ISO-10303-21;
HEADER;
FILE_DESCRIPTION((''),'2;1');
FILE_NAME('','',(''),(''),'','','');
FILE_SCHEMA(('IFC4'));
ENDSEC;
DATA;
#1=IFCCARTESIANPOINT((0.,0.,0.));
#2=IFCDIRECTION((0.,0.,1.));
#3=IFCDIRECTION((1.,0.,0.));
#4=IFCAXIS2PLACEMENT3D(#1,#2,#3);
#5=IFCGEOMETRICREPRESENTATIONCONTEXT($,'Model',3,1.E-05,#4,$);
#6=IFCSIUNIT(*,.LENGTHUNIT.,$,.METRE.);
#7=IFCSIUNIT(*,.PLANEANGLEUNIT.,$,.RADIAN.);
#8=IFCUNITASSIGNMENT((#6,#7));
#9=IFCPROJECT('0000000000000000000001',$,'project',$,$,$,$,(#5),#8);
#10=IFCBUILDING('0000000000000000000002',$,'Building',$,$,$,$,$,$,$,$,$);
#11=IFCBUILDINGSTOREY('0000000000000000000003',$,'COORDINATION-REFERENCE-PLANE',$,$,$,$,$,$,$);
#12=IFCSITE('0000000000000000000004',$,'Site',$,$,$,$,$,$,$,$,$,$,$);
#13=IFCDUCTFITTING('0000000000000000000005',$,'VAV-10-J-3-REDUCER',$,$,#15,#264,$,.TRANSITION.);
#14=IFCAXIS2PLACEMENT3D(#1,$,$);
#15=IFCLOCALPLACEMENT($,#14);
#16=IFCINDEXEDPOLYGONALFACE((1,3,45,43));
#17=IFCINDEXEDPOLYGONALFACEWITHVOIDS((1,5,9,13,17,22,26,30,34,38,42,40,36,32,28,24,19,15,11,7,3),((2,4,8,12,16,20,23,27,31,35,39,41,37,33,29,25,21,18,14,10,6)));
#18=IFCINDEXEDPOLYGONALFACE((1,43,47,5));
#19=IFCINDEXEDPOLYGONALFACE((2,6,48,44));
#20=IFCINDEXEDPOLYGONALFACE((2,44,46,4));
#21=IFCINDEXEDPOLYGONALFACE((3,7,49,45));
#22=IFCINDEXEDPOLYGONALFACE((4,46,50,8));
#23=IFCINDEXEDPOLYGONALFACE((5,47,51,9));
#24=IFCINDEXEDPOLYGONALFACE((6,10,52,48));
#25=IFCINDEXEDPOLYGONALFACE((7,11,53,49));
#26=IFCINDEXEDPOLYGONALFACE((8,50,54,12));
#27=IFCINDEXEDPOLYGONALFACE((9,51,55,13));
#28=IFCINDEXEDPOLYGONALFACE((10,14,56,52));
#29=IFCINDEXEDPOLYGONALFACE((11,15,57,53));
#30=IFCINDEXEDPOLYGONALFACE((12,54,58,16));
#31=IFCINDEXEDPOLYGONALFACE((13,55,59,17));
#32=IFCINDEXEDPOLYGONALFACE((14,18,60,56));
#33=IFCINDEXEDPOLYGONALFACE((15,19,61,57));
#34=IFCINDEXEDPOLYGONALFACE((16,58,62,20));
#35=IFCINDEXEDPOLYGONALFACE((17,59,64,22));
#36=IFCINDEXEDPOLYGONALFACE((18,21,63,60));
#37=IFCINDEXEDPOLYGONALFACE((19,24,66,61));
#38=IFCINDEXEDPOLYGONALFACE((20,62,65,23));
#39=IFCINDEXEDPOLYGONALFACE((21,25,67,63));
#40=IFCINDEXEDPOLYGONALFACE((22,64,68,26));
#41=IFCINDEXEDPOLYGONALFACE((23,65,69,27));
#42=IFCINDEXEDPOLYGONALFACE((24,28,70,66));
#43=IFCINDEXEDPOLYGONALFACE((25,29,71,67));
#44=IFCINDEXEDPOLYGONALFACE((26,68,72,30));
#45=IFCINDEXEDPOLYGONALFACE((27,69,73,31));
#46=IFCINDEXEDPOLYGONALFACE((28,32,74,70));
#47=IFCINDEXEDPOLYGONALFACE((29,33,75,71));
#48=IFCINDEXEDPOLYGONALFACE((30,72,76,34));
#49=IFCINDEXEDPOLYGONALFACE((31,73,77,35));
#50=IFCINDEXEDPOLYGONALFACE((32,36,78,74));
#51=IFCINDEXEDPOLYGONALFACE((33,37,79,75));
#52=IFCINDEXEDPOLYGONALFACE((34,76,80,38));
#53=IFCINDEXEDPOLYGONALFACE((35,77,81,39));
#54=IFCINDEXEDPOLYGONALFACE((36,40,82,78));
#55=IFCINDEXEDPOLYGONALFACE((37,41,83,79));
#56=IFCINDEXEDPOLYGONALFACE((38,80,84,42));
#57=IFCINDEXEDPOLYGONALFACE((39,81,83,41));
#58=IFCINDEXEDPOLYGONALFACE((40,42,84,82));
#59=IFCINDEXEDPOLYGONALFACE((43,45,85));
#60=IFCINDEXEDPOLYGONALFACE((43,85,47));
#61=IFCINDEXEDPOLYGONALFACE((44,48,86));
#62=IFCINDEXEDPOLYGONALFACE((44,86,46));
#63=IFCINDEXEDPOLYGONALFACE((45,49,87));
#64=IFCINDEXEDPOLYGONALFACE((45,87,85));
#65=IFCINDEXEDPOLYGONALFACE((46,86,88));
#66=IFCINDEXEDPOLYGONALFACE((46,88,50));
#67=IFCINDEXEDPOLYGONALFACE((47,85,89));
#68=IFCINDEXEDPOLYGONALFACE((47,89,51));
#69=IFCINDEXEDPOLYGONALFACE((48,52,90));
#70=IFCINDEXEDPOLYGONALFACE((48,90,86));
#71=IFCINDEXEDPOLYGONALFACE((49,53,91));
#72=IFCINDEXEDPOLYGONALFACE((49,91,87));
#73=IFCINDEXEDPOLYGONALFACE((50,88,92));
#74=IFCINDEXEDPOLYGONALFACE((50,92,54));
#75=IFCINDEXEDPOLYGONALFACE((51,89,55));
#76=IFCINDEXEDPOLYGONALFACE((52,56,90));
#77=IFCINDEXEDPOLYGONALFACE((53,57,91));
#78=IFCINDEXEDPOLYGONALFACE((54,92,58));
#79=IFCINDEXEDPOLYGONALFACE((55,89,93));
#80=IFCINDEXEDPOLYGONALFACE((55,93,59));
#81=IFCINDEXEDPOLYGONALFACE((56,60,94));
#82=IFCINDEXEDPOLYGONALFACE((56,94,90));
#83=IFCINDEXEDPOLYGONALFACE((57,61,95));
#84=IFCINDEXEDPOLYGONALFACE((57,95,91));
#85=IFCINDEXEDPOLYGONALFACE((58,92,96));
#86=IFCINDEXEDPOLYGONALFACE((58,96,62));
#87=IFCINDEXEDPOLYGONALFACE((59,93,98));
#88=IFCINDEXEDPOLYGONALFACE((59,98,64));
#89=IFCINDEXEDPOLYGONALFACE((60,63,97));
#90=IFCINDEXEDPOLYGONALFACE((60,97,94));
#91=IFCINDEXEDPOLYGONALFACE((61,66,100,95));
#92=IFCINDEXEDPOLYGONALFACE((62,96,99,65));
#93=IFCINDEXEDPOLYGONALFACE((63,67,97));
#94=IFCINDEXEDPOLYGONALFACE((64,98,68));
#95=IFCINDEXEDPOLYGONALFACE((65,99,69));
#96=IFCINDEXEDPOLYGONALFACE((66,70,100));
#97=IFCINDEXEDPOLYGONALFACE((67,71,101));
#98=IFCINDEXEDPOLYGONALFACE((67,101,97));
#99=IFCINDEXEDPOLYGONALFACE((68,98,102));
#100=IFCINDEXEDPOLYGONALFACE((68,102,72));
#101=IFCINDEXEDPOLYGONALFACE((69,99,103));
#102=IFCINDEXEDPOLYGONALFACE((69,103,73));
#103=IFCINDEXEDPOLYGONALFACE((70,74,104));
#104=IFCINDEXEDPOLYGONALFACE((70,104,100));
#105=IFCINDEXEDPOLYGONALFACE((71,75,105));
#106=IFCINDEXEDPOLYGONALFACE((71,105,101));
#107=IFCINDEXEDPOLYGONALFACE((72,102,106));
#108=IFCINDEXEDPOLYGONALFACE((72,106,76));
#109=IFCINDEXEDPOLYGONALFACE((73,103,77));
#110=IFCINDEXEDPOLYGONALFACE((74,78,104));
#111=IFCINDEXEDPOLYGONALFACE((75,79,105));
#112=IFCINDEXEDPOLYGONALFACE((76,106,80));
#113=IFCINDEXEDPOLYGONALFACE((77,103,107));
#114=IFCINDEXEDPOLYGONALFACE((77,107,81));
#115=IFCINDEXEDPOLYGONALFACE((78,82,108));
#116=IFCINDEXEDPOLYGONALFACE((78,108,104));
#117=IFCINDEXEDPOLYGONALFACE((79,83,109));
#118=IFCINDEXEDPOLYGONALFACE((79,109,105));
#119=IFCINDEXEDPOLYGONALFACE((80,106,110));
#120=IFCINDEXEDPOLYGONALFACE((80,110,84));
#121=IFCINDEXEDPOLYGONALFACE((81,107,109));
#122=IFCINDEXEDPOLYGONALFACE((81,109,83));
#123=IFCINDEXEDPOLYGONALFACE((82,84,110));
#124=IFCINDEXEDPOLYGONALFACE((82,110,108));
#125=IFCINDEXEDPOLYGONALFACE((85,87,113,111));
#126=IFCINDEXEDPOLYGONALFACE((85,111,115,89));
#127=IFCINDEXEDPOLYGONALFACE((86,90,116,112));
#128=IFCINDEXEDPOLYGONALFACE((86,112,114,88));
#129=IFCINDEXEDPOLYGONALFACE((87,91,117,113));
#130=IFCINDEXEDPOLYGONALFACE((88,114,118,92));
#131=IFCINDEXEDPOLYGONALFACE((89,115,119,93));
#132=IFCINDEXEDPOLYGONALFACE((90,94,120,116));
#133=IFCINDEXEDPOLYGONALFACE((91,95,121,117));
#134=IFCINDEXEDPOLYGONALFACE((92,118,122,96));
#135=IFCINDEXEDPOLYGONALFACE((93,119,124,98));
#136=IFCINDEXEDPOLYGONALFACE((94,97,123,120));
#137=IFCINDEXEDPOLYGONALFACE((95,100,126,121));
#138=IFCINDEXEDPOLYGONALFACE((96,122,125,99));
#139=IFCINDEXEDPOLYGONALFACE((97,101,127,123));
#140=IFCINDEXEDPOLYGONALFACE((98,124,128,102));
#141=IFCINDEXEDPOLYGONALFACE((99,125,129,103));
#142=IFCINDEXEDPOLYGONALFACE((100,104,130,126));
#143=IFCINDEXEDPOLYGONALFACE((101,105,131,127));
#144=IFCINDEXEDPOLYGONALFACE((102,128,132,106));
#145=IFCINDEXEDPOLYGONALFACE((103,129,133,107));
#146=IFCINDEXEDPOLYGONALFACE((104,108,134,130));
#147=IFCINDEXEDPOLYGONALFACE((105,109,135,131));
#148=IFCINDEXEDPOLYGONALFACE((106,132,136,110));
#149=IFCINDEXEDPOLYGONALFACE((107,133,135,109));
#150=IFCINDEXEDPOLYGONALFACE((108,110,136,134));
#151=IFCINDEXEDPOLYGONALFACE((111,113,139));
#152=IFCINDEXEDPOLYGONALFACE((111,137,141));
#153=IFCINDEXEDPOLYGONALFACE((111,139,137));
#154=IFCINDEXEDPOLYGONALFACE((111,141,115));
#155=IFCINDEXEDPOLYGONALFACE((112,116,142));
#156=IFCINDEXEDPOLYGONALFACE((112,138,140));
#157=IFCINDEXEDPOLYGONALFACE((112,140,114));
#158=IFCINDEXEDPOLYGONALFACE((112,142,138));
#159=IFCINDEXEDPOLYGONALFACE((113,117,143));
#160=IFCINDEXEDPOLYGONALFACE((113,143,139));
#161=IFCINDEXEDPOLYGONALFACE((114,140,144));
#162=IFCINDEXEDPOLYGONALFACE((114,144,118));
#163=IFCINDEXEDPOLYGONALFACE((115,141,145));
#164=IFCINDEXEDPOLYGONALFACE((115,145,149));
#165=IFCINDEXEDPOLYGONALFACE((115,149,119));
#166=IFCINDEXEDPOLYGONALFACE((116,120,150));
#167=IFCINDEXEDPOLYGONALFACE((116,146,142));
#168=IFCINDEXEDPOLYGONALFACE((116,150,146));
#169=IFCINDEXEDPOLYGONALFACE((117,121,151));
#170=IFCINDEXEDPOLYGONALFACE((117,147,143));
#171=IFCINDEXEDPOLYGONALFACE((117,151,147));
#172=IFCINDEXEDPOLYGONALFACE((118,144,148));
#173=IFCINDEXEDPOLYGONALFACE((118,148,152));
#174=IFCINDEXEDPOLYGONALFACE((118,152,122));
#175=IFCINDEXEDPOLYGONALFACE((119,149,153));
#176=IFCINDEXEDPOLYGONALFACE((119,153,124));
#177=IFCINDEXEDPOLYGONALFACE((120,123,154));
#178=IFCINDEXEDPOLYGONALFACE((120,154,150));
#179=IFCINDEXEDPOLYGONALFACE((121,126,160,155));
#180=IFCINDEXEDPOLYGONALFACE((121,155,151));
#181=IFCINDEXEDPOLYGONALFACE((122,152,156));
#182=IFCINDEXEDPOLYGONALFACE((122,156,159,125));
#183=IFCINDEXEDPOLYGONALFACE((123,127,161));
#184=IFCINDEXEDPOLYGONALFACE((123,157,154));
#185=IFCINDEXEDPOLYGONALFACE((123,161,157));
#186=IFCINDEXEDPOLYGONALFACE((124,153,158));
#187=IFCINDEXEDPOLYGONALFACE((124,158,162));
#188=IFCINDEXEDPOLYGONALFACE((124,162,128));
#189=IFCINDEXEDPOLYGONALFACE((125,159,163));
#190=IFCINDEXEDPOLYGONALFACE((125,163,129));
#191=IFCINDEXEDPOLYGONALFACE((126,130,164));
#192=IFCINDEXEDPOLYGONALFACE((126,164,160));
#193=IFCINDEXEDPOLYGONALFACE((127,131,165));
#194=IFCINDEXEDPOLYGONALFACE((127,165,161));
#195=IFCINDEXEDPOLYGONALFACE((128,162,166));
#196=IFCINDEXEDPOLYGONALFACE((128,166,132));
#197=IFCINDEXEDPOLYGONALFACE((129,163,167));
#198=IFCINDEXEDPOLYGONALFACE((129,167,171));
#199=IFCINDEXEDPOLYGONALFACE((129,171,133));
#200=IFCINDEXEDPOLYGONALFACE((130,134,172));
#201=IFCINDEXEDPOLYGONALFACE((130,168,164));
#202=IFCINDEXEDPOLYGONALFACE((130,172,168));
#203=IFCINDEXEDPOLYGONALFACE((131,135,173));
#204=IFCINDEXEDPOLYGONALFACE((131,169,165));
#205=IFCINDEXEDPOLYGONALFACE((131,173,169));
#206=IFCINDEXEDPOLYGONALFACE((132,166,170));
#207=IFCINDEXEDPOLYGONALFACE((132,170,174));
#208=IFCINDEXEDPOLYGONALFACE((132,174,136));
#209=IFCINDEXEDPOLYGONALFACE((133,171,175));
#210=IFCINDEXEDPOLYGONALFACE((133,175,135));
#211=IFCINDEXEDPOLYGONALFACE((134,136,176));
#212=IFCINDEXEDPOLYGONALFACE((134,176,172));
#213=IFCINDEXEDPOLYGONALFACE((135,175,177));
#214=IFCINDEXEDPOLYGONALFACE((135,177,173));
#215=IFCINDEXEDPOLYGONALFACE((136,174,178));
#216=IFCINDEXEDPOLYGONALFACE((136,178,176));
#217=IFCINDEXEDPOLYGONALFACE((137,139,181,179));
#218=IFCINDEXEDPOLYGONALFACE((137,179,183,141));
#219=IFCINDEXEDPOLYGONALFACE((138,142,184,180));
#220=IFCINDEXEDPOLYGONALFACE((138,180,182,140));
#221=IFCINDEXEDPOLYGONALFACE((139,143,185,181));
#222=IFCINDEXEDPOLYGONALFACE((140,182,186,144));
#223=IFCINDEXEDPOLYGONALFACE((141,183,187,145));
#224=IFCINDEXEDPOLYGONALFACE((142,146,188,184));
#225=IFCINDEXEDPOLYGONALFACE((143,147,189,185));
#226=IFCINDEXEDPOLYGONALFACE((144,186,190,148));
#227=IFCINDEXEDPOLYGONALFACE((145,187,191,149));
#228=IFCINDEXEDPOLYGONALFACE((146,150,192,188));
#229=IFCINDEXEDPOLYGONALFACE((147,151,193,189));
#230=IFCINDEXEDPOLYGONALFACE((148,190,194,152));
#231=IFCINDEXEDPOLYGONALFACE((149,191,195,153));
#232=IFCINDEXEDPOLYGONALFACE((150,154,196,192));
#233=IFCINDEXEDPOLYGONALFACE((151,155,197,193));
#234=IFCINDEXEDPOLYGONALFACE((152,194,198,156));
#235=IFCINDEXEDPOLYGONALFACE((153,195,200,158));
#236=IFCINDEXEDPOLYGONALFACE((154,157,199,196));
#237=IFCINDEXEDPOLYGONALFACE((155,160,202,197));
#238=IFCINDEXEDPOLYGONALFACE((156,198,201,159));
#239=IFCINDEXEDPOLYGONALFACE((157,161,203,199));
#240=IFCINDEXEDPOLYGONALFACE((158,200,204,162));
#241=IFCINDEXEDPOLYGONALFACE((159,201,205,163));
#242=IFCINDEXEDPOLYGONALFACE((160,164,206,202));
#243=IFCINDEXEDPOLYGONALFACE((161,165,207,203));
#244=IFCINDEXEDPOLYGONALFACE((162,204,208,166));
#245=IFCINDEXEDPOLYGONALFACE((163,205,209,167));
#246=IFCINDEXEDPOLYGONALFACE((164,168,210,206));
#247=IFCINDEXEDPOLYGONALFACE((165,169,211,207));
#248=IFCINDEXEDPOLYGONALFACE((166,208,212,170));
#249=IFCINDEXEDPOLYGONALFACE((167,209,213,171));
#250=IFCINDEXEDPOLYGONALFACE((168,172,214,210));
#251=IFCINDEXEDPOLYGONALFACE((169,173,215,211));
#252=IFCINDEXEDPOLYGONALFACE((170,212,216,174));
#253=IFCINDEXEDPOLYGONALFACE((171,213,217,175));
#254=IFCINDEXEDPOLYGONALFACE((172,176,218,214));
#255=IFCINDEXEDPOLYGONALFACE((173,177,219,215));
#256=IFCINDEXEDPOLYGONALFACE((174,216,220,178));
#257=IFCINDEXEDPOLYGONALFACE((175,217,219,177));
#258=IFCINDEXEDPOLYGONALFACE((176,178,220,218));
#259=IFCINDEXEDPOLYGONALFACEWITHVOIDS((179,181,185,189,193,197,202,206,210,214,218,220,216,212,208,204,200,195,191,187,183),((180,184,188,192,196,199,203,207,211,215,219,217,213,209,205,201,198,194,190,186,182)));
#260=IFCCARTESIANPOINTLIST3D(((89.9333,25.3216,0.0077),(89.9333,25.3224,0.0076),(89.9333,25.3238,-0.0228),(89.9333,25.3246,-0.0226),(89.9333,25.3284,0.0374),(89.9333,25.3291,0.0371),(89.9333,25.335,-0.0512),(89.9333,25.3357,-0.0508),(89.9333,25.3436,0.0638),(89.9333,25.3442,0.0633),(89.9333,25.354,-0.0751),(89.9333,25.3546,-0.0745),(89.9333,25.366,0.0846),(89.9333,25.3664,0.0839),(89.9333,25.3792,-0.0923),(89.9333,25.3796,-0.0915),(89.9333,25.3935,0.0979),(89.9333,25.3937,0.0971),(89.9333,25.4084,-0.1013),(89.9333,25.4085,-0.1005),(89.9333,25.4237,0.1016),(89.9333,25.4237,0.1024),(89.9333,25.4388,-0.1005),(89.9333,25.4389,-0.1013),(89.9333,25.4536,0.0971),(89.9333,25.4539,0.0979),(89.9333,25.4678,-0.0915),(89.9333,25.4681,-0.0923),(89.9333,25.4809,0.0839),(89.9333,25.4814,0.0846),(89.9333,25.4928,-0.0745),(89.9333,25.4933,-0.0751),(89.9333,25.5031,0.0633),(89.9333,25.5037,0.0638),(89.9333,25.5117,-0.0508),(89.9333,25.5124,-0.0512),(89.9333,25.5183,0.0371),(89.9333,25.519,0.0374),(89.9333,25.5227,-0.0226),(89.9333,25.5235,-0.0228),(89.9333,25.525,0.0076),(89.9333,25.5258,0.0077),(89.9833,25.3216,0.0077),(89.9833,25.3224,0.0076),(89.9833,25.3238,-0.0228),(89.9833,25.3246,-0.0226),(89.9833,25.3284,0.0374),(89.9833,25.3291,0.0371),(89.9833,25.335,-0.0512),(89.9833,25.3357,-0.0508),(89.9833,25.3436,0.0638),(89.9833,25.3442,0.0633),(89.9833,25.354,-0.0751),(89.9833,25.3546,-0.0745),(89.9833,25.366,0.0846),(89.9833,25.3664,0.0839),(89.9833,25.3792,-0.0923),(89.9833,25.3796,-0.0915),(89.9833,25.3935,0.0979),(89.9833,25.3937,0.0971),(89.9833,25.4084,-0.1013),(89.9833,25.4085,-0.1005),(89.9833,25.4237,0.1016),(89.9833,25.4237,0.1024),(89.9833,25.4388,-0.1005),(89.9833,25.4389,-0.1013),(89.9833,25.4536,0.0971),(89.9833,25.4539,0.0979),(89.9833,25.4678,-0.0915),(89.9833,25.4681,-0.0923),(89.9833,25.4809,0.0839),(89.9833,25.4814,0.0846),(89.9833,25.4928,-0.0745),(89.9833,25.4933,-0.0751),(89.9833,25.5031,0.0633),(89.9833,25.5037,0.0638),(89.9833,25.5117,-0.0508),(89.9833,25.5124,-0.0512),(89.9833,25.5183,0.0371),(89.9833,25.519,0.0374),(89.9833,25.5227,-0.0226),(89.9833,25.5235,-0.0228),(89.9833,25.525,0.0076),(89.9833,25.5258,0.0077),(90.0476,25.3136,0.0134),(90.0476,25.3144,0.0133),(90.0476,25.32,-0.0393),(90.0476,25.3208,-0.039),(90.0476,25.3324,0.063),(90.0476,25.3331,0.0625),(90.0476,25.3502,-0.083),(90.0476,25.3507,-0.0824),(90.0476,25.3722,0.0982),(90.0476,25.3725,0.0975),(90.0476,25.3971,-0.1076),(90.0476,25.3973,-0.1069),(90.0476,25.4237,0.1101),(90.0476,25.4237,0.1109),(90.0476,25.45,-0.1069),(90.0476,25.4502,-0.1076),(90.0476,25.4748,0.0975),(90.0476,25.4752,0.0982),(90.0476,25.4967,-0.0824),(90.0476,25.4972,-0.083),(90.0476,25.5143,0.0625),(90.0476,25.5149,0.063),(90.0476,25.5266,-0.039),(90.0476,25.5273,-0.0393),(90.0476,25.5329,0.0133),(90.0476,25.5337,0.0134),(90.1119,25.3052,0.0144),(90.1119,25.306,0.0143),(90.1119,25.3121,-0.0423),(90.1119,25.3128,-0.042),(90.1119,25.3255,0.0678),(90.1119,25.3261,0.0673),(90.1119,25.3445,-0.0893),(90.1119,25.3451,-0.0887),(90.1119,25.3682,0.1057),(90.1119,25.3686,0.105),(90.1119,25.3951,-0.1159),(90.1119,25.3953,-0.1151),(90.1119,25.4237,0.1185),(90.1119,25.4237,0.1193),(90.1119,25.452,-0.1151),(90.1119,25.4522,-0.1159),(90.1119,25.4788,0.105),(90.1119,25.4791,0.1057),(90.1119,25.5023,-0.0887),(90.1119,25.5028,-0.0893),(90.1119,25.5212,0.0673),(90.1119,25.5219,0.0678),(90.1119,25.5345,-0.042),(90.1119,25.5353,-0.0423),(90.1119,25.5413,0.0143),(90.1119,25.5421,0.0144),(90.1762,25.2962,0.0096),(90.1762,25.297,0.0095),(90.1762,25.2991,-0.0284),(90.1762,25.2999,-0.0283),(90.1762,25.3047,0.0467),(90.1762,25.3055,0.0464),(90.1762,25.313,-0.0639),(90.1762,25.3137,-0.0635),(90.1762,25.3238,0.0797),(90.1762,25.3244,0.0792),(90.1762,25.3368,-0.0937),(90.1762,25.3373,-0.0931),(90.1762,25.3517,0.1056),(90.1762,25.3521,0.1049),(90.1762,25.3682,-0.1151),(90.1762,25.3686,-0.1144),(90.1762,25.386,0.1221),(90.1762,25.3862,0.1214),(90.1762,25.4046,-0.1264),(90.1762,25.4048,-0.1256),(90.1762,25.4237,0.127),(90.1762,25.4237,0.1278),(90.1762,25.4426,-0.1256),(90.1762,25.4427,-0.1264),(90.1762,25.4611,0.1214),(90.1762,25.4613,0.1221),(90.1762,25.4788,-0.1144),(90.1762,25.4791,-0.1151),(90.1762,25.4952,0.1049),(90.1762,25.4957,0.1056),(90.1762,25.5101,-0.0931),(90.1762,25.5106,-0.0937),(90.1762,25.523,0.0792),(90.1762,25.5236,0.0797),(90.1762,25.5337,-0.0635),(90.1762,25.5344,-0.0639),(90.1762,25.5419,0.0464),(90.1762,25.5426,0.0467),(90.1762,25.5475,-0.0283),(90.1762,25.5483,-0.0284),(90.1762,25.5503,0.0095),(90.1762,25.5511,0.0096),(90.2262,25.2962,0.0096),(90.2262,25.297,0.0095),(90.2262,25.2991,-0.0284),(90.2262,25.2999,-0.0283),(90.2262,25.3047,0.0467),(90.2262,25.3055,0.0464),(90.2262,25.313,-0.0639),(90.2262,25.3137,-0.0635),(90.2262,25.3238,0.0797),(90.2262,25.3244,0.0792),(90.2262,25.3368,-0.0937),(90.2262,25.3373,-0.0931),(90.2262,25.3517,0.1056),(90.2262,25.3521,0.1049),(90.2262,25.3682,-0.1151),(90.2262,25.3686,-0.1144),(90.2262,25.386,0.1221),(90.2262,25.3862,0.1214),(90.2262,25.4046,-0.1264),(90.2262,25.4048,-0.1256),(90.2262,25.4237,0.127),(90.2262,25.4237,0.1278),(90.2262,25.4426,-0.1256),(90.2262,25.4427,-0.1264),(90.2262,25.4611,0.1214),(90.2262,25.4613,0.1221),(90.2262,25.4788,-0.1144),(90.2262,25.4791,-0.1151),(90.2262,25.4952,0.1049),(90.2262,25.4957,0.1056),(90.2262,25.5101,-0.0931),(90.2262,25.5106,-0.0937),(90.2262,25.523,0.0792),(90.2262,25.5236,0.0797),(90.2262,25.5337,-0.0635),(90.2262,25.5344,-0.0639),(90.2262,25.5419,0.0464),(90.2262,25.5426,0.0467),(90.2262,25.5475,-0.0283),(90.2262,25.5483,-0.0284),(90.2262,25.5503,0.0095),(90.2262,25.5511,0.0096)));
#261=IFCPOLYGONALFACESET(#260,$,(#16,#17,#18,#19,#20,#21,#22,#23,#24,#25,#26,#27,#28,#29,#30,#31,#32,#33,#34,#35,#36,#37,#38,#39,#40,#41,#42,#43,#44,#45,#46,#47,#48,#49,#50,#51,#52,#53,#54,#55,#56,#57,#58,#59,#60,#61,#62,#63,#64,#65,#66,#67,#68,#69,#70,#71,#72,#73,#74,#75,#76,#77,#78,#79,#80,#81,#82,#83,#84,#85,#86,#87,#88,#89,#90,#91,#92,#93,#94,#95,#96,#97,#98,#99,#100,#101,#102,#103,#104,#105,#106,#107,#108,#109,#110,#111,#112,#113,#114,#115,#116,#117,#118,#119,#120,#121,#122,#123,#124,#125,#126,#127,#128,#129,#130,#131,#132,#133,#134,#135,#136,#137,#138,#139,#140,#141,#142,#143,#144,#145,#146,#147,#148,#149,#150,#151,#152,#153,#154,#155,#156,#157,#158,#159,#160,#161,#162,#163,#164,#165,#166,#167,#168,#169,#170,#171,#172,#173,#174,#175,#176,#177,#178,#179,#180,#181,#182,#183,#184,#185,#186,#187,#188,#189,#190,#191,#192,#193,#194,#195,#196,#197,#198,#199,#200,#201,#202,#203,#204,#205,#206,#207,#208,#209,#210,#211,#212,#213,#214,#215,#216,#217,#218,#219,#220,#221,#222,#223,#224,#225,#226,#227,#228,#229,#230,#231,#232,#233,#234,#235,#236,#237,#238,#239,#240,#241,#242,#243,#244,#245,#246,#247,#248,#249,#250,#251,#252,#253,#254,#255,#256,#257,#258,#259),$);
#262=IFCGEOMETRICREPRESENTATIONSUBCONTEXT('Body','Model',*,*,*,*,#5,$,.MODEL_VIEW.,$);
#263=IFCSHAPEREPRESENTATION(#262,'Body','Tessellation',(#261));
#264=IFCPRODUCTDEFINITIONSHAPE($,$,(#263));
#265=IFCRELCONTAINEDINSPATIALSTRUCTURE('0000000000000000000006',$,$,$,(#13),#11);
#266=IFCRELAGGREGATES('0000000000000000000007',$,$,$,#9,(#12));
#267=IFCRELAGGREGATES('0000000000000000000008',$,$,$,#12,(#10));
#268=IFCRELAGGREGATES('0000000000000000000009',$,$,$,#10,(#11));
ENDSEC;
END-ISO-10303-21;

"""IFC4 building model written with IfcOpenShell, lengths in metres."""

from ifc_helpers import new_model, entity, si_unit, frame, origin_with_axes, place, context, subcontext, project, spatial, element, save


model = new_model("IFC4")

# Units and contexts
model_context = context("Model", 3, precision=1e-05, world=origin_with_axes())
body_context_1 = subcontext(model_context, "Body", "Model", "MODEL_VIEW")
ifc_project = project(units=[si_unit("LENGTHUNIT", "METRE"), si_unit("PLANEANGLEUNIT", "RADIAN")], contexts=[model_context])

# Site, building, storey
site = spatial("IfcSite", under=ifc_project, Name="Site")
building = spatial("IfcBuilding", under=site, Name="Building")
storey = spatial("IfcBuildingStorey", under=building, Name="COORDINATION-REFERENCE-PLANE")

# Duct fitting
for number, where, z_axis, x_axis, name in (
    (1, (90.2262, 25.4237, 0.0), (0.0, -1.0, 0.0), (0.0, 0.0, 1.0), "VAV-10-J-3-REDUCER"),
):
    element("IfcDuctFitting", number, at=place(None, frame(where, z_axis=z_axis, x_axis=x_axis)), inside=storey, Name=name, PredefinedType="TRANSITION", context=body_context_1, shape_type="SweptSolid", body=[
        entity("IfcRevolvedAreaSolid", entity("IfcArbitraryClosedProfileDef", "AREA", None, entity("IfcPolyline", [entity("IfcCartesianPoint", [0.1278, 0.0]), entity("IfcCartesianPoint", [0.1278, 0.05]), entity("IfcCartesianPoint", [0.1024, 0.2429]), entity("IfcCartesianPoint", [0.1024, 0.2929]), entity("IfcCartesianPoint", [0.1016, 0.2929]), entity("IfcCartesianPoint", [0.1016, 0.2429]), entity("IfcCartesianPoint", [0.127, 0.05]), entity("IfcCartesianPoint", [0.127, 0.0]), entity("IfcCartesianPoint", [0.1278, 0.0])])), entity("IfcAxis2Placement3D", entity("IfcCartesianPoint", [0.0, 0.0, 0.0])), entity("IfcAxis1Placement", entity("IfcCartesianPoint", [0.0, 0.0, 0.0]), entity("IfcDirection", [0.0, 1.0, 0.0])), 6.283185),
    ])

save(model, "model.ifc")
